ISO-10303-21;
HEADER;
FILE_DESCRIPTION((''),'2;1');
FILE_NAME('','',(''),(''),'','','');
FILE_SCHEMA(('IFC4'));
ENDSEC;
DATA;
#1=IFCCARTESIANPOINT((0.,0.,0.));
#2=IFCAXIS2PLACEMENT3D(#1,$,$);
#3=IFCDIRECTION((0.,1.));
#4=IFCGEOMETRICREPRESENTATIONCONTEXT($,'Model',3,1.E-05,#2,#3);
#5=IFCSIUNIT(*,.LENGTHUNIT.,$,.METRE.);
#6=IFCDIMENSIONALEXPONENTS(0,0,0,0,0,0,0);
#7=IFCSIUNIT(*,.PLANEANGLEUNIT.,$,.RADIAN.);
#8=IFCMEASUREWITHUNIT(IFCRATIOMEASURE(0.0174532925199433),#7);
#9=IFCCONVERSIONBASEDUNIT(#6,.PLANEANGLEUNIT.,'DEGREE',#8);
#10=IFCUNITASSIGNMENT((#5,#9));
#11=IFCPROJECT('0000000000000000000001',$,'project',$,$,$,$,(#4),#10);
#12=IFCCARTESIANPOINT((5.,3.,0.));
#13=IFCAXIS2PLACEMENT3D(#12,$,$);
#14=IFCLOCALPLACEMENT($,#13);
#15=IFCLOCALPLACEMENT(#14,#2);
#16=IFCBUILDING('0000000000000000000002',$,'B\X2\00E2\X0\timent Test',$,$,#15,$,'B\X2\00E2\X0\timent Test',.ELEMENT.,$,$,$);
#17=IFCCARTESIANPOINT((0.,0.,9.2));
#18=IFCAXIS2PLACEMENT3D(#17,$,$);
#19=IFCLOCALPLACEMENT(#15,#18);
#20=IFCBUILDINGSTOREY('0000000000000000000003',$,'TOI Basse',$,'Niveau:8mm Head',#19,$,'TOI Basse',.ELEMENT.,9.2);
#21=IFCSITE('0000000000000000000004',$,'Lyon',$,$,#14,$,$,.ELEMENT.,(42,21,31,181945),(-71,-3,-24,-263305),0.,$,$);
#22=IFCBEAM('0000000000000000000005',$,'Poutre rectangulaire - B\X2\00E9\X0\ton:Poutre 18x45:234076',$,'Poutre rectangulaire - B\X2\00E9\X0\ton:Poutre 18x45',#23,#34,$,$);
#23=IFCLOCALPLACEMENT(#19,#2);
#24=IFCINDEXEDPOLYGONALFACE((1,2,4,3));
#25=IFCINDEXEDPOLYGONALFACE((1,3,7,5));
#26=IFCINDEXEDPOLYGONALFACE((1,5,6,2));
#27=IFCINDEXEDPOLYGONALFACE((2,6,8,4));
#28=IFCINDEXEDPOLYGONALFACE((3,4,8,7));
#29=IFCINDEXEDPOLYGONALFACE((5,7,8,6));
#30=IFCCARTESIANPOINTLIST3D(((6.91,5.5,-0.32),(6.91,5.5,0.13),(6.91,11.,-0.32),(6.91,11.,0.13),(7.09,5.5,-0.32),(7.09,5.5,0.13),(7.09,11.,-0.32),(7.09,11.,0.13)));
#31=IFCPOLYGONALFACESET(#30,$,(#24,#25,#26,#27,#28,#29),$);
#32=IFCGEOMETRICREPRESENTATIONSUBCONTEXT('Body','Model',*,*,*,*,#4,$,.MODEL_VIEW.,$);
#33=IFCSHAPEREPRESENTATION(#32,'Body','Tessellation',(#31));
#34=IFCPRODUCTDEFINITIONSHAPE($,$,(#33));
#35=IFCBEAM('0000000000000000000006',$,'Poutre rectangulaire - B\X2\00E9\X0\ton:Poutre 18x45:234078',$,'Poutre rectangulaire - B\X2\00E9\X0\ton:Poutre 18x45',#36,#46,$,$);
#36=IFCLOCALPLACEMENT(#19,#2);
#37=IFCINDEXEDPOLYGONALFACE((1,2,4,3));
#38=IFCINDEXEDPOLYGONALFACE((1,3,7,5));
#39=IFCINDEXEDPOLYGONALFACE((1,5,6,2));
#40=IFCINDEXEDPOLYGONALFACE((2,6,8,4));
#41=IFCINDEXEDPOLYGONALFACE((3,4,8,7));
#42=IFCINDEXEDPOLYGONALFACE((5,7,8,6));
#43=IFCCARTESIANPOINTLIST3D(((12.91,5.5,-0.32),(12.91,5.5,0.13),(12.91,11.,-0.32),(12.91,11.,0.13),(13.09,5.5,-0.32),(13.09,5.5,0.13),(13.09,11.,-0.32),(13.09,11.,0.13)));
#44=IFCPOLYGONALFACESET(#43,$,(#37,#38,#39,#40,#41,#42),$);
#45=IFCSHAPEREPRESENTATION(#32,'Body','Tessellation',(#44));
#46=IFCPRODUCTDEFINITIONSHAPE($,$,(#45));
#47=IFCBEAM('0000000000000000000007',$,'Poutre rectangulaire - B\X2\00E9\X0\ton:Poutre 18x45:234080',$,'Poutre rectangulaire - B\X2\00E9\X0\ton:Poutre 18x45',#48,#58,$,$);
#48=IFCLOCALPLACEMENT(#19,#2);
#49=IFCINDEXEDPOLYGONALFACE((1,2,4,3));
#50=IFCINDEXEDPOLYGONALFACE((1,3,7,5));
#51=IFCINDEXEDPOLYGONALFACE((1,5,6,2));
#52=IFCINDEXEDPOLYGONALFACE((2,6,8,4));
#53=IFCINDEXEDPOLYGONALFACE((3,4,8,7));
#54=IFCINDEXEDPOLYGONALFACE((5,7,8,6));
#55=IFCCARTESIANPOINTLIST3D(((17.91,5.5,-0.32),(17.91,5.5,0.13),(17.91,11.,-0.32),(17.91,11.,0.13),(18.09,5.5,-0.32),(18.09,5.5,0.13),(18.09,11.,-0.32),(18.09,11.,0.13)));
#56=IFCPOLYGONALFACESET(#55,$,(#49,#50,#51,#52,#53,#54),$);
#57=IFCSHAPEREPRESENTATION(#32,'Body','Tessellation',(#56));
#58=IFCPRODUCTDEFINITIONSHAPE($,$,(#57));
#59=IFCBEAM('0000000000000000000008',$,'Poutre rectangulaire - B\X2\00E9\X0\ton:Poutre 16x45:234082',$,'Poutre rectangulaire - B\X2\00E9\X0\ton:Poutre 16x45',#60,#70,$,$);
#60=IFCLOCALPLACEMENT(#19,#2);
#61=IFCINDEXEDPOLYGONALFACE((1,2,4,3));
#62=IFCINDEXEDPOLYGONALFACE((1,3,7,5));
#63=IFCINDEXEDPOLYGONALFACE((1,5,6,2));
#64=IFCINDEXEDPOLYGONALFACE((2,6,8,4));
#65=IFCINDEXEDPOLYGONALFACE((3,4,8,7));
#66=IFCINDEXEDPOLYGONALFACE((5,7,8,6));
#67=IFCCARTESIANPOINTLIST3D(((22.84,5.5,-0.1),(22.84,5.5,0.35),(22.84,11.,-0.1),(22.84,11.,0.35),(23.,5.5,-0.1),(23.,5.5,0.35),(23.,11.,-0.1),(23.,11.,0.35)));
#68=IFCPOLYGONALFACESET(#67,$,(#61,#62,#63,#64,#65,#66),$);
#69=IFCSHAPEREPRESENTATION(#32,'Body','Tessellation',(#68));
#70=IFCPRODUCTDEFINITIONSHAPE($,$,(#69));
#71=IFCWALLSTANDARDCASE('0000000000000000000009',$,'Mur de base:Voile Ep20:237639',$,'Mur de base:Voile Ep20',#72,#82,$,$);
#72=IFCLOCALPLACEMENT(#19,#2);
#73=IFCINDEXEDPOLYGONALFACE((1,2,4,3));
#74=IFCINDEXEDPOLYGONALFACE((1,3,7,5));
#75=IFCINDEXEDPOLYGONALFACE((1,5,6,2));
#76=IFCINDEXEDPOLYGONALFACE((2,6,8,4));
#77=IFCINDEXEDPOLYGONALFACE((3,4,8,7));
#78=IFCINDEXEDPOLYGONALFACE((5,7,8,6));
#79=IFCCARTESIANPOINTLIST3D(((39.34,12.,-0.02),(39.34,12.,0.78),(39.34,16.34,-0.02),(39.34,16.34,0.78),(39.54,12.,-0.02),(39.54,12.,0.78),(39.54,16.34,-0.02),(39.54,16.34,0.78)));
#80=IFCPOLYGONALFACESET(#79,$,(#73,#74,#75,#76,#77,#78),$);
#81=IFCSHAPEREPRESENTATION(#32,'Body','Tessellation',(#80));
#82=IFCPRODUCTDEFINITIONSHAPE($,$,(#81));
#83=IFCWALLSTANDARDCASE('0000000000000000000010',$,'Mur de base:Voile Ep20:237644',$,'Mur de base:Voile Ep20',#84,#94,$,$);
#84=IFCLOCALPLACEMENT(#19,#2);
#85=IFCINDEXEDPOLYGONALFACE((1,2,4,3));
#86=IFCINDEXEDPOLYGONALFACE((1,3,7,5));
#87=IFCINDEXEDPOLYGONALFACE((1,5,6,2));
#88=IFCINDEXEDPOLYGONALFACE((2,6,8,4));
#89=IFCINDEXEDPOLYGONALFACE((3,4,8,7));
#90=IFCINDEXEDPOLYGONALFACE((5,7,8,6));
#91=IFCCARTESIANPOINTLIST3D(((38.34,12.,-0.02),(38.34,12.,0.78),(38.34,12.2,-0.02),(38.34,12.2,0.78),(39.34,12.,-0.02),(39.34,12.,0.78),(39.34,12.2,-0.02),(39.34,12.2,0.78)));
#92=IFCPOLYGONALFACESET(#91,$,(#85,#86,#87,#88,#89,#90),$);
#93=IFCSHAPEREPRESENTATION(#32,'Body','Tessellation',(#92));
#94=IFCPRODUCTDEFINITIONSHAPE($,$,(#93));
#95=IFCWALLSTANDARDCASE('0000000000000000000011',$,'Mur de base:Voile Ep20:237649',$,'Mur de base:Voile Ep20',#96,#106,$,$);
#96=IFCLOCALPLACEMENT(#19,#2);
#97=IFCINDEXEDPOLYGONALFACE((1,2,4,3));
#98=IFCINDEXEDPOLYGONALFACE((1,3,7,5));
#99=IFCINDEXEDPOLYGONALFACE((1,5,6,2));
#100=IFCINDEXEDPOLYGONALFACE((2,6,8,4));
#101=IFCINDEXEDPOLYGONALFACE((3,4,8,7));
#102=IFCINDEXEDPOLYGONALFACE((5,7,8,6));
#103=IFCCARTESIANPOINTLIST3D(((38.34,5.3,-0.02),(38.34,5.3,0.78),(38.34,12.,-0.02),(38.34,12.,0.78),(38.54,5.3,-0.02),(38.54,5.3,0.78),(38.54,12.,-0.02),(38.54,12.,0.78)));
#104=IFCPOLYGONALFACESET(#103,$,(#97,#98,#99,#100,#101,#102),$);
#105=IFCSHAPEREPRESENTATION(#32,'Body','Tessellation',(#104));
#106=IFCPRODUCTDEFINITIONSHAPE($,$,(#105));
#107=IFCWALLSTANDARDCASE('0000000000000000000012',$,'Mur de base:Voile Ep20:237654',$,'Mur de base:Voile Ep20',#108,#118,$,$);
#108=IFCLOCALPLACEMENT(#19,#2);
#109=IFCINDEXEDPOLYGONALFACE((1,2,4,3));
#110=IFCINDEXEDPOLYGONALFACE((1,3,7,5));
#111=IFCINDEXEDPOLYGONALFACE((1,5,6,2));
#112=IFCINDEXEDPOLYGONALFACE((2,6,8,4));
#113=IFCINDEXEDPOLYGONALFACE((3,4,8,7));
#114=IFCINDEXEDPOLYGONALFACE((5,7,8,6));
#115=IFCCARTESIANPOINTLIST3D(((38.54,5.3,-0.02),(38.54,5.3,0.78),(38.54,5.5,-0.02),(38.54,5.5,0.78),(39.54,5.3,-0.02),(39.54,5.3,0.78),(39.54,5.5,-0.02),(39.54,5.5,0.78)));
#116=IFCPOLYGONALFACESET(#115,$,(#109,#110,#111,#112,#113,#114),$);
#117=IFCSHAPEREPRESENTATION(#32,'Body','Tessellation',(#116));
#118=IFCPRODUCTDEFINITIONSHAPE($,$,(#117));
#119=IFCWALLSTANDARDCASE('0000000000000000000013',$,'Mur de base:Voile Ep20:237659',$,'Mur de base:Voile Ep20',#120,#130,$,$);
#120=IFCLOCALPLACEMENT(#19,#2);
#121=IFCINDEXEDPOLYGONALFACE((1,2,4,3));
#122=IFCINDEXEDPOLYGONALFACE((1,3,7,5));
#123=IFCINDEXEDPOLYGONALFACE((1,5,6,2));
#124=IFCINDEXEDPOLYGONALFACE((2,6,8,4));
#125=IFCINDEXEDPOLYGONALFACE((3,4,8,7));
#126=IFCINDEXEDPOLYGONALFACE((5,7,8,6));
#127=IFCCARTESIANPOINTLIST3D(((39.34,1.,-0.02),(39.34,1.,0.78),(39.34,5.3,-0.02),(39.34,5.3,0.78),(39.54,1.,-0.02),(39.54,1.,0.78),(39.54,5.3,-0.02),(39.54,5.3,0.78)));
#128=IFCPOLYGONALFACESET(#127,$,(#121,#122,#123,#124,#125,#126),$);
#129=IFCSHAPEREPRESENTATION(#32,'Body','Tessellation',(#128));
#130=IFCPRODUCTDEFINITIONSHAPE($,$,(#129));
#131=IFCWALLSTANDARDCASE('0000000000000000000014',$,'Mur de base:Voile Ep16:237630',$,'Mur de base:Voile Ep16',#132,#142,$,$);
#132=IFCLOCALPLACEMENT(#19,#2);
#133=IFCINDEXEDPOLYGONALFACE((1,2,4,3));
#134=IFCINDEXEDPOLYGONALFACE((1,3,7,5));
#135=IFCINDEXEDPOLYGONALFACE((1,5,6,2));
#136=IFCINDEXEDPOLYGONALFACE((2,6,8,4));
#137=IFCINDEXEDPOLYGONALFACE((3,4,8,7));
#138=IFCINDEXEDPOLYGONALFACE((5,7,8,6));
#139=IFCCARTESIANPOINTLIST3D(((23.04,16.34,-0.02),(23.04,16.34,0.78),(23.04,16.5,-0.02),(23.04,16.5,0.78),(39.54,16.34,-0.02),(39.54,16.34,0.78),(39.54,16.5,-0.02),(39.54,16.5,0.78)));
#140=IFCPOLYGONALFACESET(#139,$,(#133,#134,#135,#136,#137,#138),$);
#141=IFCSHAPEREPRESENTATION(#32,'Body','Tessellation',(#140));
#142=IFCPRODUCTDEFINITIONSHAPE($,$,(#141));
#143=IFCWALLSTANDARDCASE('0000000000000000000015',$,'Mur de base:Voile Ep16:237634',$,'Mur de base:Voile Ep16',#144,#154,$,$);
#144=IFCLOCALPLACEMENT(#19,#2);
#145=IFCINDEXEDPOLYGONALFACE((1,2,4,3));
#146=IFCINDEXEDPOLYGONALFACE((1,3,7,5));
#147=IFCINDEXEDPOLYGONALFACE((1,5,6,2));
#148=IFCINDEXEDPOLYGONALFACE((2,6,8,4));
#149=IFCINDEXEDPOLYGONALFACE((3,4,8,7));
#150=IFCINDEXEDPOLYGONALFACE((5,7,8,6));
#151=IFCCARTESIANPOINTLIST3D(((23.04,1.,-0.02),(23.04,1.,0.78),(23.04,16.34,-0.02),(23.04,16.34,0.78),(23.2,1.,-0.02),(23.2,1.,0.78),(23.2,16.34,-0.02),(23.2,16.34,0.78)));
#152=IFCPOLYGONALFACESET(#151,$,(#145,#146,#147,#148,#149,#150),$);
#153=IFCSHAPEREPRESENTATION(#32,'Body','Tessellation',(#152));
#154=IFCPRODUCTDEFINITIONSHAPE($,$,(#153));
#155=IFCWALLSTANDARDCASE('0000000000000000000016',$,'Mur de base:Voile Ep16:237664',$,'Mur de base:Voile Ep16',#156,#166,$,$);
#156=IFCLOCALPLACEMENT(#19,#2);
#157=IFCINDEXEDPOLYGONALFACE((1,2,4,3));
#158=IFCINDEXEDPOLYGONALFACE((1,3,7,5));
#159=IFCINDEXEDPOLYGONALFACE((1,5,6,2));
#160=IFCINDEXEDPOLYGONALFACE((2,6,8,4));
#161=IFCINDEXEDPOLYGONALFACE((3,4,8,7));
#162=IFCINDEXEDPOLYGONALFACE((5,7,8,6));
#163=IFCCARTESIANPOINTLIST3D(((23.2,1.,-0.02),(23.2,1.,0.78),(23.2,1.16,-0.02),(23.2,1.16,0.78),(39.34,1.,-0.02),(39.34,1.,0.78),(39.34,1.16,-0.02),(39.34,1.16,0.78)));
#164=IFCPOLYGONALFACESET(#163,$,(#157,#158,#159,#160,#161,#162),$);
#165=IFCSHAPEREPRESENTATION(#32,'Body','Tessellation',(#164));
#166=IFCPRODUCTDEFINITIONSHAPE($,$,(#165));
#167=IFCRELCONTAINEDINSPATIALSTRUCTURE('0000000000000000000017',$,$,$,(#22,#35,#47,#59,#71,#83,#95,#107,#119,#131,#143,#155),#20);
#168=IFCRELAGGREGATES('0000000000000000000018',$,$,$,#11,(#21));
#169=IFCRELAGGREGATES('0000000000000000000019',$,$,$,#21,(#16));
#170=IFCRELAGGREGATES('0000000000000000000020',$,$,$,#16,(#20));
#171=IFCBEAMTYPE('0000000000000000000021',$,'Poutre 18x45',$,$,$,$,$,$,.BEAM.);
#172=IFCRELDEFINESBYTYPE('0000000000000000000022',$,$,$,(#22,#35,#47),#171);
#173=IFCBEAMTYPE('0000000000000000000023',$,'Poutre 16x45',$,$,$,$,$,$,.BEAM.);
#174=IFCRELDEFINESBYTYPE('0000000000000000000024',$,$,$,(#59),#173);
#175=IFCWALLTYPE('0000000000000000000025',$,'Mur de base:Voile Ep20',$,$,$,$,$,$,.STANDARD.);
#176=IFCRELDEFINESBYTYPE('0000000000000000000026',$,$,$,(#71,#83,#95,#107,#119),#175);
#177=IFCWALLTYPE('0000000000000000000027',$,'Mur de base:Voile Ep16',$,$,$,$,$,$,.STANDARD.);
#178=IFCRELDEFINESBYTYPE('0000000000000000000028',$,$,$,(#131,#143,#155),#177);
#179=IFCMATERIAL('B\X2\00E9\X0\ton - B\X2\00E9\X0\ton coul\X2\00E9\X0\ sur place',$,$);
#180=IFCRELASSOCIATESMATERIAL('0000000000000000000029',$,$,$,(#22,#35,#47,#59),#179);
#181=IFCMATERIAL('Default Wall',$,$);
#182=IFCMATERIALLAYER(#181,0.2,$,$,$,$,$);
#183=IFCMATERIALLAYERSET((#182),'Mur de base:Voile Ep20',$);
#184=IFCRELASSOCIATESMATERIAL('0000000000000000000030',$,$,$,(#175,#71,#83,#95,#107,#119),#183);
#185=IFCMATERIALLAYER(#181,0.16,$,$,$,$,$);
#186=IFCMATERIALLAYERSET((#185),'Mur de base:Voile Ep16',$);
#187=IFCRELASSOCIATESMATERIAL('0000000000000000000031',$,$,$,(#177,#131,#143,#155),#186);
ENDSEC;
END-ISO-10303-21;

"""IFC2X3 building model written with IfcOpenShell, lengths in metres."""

from ifc_helpers import new_model, entity, si_unit, converted_unit, direction, frame, frame_2d, origin, place, context, subcontext, project, spatial, rectangle, extrude, material, layer, layer_set, layer_usage, type_object, element, save


model = new_model("IFC2X3")

# Units and contexts
model_context = context("Model", 3, precision=1e-05, world=origin(), true_north=direction((0.0, 1.0)))
body_context = subcontext(model_context, "Body", "Model", "MODEL_VIEW")
ifc_project = project(units=[si_unit("LENGTHUNIT", "METRE"), converted_unit("PLANEANGLEUNIT", "DEGREE", entity("IfcRatioMeasure", 0.0174532925199433), si_unit("PLANEANGLEUNIT", "RADIAN"), dimensions=[0, 0, 0, 0, 0, 0, 0])], contexts=[model_context])

# Site, building, storey
site_placement = place(None, frame((5.0, 3.0, 0.0)))
site = spatial("IfcSite", under=ifc_project, at=site_placement, Name="Lyon", CompositionType="ELEMENT", RefLatitude=(42, 21, 31, 181945), RefLongitude=(-71, -3, -24, -263305), RefElevation=0.0)
building_placement = place(site_placement, origin())
building = spatial("IfcBuilding", under=site, at=building_placement, Name="Bâtiment Test", LongName="Bâtiment Test", CompositionType="ELEMENT")
storey_placement = place(building_placement, frame((0.0, 0.0, 9.2)))
storey = spatial("IfcBuildingStorey", under=building, at=storey_placement, Name="TOI Basse", ObjectType="Niveau:8mm Head", LongName="TOI Basse", CompositionType="ELEMENT", Elevation=9.2)

# Beams
ifc_material_1 = material(Name="Béton - Béton coulé sur place")
beam_type_1 = type_object("IfcBeamType", Name="Poutre 18x45", PredefinedType="BEAM")
beam_1_placement = place(storey_placement, frame((7.0, 11.0, 0.13), z_axis=(0.0, 0.0, 1.0), x_axis=(0.0, -1.0, 0.0)))
element("IfcBeam", 1, at=beam_1_placement, inside=storey, type_object=beam_type_1, material=ifc_material_1, Name="Poutre rectangulaire - Béton:Poutre 18x45:234076", ObjectType="Poutre rectangulaire - Béton:Poutre 18x45", context=body_context, shape_type="SweptSolid", body=[
    extrude(rectangle(XDim=0.45, YDim=0.18, at=frame_2d((0.0, 0.0), x_axis=(1.0, 0.0))), frame((0.0, 0.0, -0.225), z_axis=(1.0, 0.0, 0.0), x_axis=(0.0, 0.0, -1.0)), (0.0, 0.0, 1.0), 5.5),
])
beam_2_placement = place(storey_placement, frame((13.0, 11.0, 0.13), z_axis=(0.0, 0.0, 1.0), x_axis=(0.0, -1.0, 0.0)))
element("IfcBeam", 2, at=beam_2_placement, inside=storey, type_object=beam_type_1, material=ifc_material_1, Name="Poutre rectangulaire - Béton:Poutre 18x45:234078", ObjectType="Poutre rectangulaire - Béton:Poutre 18x45", context=body_context, shape_type="SweptSolid", body=[
    extrude(rectangle(XDim=0.45, YDim=0.18, at=frame_2d((0.0, 0.0), x_axis=(1.0, 0.0))), frame((0.0, 0.0, -0.225), z_axis=(1.0, 0.0, 0.0), x_axis=(0.0, 0.0, -1.0)), (0.0, 0.0, 1.0), 5.5),
])
beam_3_placement = place(storey_placement, frame((18.0, 5.5, 0.13), z_axis=(0.0, 0.0, 1.0), x_axis=(0.0, 1.0, 0.0)))
element("IfcBeam", 3, at=beam_3_placement, inside=storey, type_object=beam_type_1, material=ifc_material_1, Name="Poutre rectangulaire - Béton:Poutre 18x45:234080", ObjectType="Poutre rectangulaire - Béton:Poutre 18x45", context=body_context, shape_type="SweptSolid", body=[
    extrude(rectangle(XDim=0.45, YDim=0.18, at=frame_2d((0.0, 0.0), x_axis=(1.0, 0.0))), frame((0.0, 0.0, -0.225), z_axis=(1.0, 0.0, 0.0), x_axis=(0.0, 0.0, -1.0)), (0.0, 0.0, 1.0), 5.5),
])
beam_type_2 = type_object("IfcBeamType", Name="Poutre 16x45", PredefinedType="BEAM")
beam_4_placement = place(storey_placement, frame((22.92, 5.5, 0.35), z_axis=(0.0, 0.0, 1.0), x_axis=(0.0, 1.0, 0.0)))
element("IfcBeam", 4, at=beam_4_placement, inside=storey, type_object=beam_type_2, material=ifc_material_1, Name="Poutre rectangulaire - Béton:Poutre 16x45:234082", ObjectType="Poutre rectangulaire - Béton:Poutre 16x45", context=body_context, shape_type="SweptSolid", body=[
    extrude(rectangle(XDim=0.45, YDim=0.16, at=frame_2d((0.0, 0.0), x_axis=(1.0, 0.0))), frame((0.0, 0.0, -0.225), z_axis=(1.0, 0.0, 0.0), x_axis=(0.0, 0.0, -1.0)), (0.0, 0.0, 1.0), 5.5),
])

# Walls
ifc_material_2 = material(Name="Default Wall")
ifc_layer_1 = layer(ifc_material_2, 0.2)
ifc_layer_set_1 = layer_set([ifc_layer_1], Name="Mur de base:Voile Ep20")
ifc_layer_usage_1 = layer_usage(ifc_layer_set_1, "AXIS2", "NEGATIVE", 0.1)
wall_type_1 = type_object("IfcWallType", Name="Mur de base:Voile Ep20", PredefinedType="STANDARD", material=ifc_layer_set_1)
wall_1_placement = place(storey_placement, frame((39.44, 12.0, -0.02), z_axis=(0.0, 0.0, 1.0), x_axis=(0.0, 1.0, 0.0)))
element("IfcWallStandardCase", 5, at=wall_1_placement, inside=storey, type_object=wall_type_1, material=ifc_layer_usage_1, Name="Mur de base:Voile Ep20:237639", ObjectType="Mur de base:Voile Ep20", context=body_context, shape_type="SweptSolid", body=[
    extrude(rectangle(XDim=4.34, YDim=0.2, at=frame_2d((2.17, 0.0), x_axis=(-1.0, 0.0))), origin(), (0.0, 0.0, 1.0), 0.8),
])
ifc_layer_usage_2 = layer_usage(ifc_layer_set_1, "AXIS2", "NEGATIVE", 0.1)
wall_2_placement = place(storey_placement, frame((38.34, 12.1, -0.02)))
element("IfcWallStandardCase", 6, at=wall_2_placement, inside=storey, type_object=wall_type_1, material=ifc_layer_usage_2, Name="Mur de base:Voile Ep20:237644", ObjectType="Mur de base:Voile Ep20", context=body_context, shape_type="SweptSolid", body=[
    extrude(rectangle(XDim=1.0, YDim=0.2, at=frame_2d((0.5, 0.0), x_axis=(-1.0, 0.0))), origin(), (0.0, 0.0, 1.0), 0.8),
])
ifc_layer_usage_3 = layer_usage(ifc_layer_set_1, "AXIS2", "NEGATIVE", 0.1)
wall_3_placement = place(storey_placement, frame((38.44, 5.3, -0.02), z_axis=(0.0, 0.0, 1.0), x_axis=(0.0, 1.0, 0.0)))
element("IfcWallStandardCase", 7, at=wall_3_placement, inside=storey, type_object=wall_type_1, material=ifc_layer_usage_3, Name="Mur de base:Voile Ep20:237649", ObjectType="Mur de base:Voile Ep20", context=body_context, shape_type="SweptSolid", body=[
    extrude(rectangle(XDim=6.7, YDim=0.2, at=frame_2d((3.35, 0.0), x_axis=(-1.0, 0.0))), origin(), (0.0, 0.0, 1.0), 0.8),
])
ifc_layer_usage_4 = layer_usage(ifc_layer_set_1, "AXIS2", "NEGATIVE", 0.1)
wall_4_placement = place(storey_placement, frame((39.54, 5.4, -0.02), z_axis=(0.0, 0.0, 1.0), x_axis=(-1.0, 0.0, 0.0)))
element("IfcWallStandardCase", 8, at=wall_4_placement, inside=storey, type_object=wall_type_1, material=ifc_layer_usage_4, Name="Mur de base:Voile Ep20:237654", ObjectType="Mur de base:Voile Ep20", context=body_context, shape_type="SweptSolid", body=[
    extrude(rectangle(XDim=1.0, YDim=0.2, at=frame_2d((0.5, 0.0), x_axis=(-1.0, 0.0))), origin(), (0.0, 0.0, 1.0), 0.8),
])
ifc_layer_usage_5 = layer_usage(ifc_layer_set_1, "AXIS2", "NEGATIVE", 0.1)
wall_5_placement = place(storey_placement, frame((39.44, 1.0, -0.02), z_axis=(0.0, 0.0, 1.0), x_axis=(0.0, 1.0, 0.0)))
element("IfcWallStandardCase", 9, at=wall_5_placement, inside=storey, type_object=wall_type_1, material=ifc_layer_usage_5, Name="Mur de base:Voile Ep20:237659", ObjectType="Mur de base:Voile Ep20", context=body_context, shape_type="SweptSolid", body=[
    extrude(rectangle(XDim=4.3, YDim=0.2, at=frame_2d((2.15, 0.0), x_axis=(-1.0, 0.0))), origin(), (0.0, 0.0, 1.0), 0.8),
])
ifc_layer_2 = layer(ifc_material_2, 0.16)
ifc_layer_set_2 = layer_set([ifc_layer_2], Name="Mur de base:Voile Ep16")
ifc_layer_usage_6 = layer_usage(ifc_layer_set_2, "AXIS2", "NEGATIVE", 0.08)
wall_type_2 = type_object("IfcWallType", Name="Mur de base:Voile Ep16", PredefinedType="STANDARD", material=ifc_layer_set_2)
wall_6_placement = place(storey_placement, frame((39.54, 16.42, -0.02), z_axis=(0.0, 0.0, 1.0), x_axis=(-1.0, 0.0, 0.0)))
element("IfcWallStandardCase", 10, at=wall_6_placement, inside=storey, type_object=wall_type_2, material=ifc_layer_usage_6, Name="Mur de base:Voile Ep16:237630", ObjectType="Mur de base:Voile Ep16", context=body_context, shape_type="SweptSolid", body=[
    extrude(rectangle(XDim=16.5, YDim=0.16, at=frame_2d((8.25, 0.0), x_axis=(-1.0, 0.0))), origin(), (0.0, 0.0, 1.0), 0.8),
])
ifc_layer_usage_7 = layer_usage(ifc_layer_set_2, "AXIS2", "NEGATIVE", 0.08)
wall_7_placement = place(storey_placement, frame((23.12, 16.34, -0.02), z_axis=(0.0, 0.0, 1.0), x_axis=(0.0, -1.0, 0.0)))
element("IfcWallStandardCase", 11, at=wall_7_placement, inside=storey, type_object=wall_type_2, material=ifc_layer_usage_7, Name="Mur de base:Voile Ep16:237634", ObjectType="Mur de base:Voile Ep16", context=body_context, shape_type="SweptSolid", body=[
    extrude(rectangle(XDim=15.34, YDim=0.16, at=frame_2d((7.67, 0.0), x_axis=(-1.0, 0.0))), origin(), (0.0, 0.0, 1.0), 0.8),
])
ifc_layer_usage_8 = layer_usage(ifc_layer_set_2, "AXIS2", "NEGATIVE", 0.08)
wall_8_placement = place(storey_placement, frame((23.2, 1.08, -0.02)))
element("IfcWallStandardCase", 12, at=wall_8_placement, inside=storey, type_object=wall_type_2, material=ifc_layer_usage_8, Name="Mur de base:Voile Ep16:237664", ObjectType="Mur de base:Voile Ep16", context=body_context, shape_type="SweptSolid", body=[
    extrude(rectangle(XDim=16.14, YDim=0.16, at=frame_2d((8.07, 0.0), x_axis=(-1.0, 0.0))), origin(), (0.0, 0.0, 1.0), 0.8),
])

save(model, "model.ifc")
